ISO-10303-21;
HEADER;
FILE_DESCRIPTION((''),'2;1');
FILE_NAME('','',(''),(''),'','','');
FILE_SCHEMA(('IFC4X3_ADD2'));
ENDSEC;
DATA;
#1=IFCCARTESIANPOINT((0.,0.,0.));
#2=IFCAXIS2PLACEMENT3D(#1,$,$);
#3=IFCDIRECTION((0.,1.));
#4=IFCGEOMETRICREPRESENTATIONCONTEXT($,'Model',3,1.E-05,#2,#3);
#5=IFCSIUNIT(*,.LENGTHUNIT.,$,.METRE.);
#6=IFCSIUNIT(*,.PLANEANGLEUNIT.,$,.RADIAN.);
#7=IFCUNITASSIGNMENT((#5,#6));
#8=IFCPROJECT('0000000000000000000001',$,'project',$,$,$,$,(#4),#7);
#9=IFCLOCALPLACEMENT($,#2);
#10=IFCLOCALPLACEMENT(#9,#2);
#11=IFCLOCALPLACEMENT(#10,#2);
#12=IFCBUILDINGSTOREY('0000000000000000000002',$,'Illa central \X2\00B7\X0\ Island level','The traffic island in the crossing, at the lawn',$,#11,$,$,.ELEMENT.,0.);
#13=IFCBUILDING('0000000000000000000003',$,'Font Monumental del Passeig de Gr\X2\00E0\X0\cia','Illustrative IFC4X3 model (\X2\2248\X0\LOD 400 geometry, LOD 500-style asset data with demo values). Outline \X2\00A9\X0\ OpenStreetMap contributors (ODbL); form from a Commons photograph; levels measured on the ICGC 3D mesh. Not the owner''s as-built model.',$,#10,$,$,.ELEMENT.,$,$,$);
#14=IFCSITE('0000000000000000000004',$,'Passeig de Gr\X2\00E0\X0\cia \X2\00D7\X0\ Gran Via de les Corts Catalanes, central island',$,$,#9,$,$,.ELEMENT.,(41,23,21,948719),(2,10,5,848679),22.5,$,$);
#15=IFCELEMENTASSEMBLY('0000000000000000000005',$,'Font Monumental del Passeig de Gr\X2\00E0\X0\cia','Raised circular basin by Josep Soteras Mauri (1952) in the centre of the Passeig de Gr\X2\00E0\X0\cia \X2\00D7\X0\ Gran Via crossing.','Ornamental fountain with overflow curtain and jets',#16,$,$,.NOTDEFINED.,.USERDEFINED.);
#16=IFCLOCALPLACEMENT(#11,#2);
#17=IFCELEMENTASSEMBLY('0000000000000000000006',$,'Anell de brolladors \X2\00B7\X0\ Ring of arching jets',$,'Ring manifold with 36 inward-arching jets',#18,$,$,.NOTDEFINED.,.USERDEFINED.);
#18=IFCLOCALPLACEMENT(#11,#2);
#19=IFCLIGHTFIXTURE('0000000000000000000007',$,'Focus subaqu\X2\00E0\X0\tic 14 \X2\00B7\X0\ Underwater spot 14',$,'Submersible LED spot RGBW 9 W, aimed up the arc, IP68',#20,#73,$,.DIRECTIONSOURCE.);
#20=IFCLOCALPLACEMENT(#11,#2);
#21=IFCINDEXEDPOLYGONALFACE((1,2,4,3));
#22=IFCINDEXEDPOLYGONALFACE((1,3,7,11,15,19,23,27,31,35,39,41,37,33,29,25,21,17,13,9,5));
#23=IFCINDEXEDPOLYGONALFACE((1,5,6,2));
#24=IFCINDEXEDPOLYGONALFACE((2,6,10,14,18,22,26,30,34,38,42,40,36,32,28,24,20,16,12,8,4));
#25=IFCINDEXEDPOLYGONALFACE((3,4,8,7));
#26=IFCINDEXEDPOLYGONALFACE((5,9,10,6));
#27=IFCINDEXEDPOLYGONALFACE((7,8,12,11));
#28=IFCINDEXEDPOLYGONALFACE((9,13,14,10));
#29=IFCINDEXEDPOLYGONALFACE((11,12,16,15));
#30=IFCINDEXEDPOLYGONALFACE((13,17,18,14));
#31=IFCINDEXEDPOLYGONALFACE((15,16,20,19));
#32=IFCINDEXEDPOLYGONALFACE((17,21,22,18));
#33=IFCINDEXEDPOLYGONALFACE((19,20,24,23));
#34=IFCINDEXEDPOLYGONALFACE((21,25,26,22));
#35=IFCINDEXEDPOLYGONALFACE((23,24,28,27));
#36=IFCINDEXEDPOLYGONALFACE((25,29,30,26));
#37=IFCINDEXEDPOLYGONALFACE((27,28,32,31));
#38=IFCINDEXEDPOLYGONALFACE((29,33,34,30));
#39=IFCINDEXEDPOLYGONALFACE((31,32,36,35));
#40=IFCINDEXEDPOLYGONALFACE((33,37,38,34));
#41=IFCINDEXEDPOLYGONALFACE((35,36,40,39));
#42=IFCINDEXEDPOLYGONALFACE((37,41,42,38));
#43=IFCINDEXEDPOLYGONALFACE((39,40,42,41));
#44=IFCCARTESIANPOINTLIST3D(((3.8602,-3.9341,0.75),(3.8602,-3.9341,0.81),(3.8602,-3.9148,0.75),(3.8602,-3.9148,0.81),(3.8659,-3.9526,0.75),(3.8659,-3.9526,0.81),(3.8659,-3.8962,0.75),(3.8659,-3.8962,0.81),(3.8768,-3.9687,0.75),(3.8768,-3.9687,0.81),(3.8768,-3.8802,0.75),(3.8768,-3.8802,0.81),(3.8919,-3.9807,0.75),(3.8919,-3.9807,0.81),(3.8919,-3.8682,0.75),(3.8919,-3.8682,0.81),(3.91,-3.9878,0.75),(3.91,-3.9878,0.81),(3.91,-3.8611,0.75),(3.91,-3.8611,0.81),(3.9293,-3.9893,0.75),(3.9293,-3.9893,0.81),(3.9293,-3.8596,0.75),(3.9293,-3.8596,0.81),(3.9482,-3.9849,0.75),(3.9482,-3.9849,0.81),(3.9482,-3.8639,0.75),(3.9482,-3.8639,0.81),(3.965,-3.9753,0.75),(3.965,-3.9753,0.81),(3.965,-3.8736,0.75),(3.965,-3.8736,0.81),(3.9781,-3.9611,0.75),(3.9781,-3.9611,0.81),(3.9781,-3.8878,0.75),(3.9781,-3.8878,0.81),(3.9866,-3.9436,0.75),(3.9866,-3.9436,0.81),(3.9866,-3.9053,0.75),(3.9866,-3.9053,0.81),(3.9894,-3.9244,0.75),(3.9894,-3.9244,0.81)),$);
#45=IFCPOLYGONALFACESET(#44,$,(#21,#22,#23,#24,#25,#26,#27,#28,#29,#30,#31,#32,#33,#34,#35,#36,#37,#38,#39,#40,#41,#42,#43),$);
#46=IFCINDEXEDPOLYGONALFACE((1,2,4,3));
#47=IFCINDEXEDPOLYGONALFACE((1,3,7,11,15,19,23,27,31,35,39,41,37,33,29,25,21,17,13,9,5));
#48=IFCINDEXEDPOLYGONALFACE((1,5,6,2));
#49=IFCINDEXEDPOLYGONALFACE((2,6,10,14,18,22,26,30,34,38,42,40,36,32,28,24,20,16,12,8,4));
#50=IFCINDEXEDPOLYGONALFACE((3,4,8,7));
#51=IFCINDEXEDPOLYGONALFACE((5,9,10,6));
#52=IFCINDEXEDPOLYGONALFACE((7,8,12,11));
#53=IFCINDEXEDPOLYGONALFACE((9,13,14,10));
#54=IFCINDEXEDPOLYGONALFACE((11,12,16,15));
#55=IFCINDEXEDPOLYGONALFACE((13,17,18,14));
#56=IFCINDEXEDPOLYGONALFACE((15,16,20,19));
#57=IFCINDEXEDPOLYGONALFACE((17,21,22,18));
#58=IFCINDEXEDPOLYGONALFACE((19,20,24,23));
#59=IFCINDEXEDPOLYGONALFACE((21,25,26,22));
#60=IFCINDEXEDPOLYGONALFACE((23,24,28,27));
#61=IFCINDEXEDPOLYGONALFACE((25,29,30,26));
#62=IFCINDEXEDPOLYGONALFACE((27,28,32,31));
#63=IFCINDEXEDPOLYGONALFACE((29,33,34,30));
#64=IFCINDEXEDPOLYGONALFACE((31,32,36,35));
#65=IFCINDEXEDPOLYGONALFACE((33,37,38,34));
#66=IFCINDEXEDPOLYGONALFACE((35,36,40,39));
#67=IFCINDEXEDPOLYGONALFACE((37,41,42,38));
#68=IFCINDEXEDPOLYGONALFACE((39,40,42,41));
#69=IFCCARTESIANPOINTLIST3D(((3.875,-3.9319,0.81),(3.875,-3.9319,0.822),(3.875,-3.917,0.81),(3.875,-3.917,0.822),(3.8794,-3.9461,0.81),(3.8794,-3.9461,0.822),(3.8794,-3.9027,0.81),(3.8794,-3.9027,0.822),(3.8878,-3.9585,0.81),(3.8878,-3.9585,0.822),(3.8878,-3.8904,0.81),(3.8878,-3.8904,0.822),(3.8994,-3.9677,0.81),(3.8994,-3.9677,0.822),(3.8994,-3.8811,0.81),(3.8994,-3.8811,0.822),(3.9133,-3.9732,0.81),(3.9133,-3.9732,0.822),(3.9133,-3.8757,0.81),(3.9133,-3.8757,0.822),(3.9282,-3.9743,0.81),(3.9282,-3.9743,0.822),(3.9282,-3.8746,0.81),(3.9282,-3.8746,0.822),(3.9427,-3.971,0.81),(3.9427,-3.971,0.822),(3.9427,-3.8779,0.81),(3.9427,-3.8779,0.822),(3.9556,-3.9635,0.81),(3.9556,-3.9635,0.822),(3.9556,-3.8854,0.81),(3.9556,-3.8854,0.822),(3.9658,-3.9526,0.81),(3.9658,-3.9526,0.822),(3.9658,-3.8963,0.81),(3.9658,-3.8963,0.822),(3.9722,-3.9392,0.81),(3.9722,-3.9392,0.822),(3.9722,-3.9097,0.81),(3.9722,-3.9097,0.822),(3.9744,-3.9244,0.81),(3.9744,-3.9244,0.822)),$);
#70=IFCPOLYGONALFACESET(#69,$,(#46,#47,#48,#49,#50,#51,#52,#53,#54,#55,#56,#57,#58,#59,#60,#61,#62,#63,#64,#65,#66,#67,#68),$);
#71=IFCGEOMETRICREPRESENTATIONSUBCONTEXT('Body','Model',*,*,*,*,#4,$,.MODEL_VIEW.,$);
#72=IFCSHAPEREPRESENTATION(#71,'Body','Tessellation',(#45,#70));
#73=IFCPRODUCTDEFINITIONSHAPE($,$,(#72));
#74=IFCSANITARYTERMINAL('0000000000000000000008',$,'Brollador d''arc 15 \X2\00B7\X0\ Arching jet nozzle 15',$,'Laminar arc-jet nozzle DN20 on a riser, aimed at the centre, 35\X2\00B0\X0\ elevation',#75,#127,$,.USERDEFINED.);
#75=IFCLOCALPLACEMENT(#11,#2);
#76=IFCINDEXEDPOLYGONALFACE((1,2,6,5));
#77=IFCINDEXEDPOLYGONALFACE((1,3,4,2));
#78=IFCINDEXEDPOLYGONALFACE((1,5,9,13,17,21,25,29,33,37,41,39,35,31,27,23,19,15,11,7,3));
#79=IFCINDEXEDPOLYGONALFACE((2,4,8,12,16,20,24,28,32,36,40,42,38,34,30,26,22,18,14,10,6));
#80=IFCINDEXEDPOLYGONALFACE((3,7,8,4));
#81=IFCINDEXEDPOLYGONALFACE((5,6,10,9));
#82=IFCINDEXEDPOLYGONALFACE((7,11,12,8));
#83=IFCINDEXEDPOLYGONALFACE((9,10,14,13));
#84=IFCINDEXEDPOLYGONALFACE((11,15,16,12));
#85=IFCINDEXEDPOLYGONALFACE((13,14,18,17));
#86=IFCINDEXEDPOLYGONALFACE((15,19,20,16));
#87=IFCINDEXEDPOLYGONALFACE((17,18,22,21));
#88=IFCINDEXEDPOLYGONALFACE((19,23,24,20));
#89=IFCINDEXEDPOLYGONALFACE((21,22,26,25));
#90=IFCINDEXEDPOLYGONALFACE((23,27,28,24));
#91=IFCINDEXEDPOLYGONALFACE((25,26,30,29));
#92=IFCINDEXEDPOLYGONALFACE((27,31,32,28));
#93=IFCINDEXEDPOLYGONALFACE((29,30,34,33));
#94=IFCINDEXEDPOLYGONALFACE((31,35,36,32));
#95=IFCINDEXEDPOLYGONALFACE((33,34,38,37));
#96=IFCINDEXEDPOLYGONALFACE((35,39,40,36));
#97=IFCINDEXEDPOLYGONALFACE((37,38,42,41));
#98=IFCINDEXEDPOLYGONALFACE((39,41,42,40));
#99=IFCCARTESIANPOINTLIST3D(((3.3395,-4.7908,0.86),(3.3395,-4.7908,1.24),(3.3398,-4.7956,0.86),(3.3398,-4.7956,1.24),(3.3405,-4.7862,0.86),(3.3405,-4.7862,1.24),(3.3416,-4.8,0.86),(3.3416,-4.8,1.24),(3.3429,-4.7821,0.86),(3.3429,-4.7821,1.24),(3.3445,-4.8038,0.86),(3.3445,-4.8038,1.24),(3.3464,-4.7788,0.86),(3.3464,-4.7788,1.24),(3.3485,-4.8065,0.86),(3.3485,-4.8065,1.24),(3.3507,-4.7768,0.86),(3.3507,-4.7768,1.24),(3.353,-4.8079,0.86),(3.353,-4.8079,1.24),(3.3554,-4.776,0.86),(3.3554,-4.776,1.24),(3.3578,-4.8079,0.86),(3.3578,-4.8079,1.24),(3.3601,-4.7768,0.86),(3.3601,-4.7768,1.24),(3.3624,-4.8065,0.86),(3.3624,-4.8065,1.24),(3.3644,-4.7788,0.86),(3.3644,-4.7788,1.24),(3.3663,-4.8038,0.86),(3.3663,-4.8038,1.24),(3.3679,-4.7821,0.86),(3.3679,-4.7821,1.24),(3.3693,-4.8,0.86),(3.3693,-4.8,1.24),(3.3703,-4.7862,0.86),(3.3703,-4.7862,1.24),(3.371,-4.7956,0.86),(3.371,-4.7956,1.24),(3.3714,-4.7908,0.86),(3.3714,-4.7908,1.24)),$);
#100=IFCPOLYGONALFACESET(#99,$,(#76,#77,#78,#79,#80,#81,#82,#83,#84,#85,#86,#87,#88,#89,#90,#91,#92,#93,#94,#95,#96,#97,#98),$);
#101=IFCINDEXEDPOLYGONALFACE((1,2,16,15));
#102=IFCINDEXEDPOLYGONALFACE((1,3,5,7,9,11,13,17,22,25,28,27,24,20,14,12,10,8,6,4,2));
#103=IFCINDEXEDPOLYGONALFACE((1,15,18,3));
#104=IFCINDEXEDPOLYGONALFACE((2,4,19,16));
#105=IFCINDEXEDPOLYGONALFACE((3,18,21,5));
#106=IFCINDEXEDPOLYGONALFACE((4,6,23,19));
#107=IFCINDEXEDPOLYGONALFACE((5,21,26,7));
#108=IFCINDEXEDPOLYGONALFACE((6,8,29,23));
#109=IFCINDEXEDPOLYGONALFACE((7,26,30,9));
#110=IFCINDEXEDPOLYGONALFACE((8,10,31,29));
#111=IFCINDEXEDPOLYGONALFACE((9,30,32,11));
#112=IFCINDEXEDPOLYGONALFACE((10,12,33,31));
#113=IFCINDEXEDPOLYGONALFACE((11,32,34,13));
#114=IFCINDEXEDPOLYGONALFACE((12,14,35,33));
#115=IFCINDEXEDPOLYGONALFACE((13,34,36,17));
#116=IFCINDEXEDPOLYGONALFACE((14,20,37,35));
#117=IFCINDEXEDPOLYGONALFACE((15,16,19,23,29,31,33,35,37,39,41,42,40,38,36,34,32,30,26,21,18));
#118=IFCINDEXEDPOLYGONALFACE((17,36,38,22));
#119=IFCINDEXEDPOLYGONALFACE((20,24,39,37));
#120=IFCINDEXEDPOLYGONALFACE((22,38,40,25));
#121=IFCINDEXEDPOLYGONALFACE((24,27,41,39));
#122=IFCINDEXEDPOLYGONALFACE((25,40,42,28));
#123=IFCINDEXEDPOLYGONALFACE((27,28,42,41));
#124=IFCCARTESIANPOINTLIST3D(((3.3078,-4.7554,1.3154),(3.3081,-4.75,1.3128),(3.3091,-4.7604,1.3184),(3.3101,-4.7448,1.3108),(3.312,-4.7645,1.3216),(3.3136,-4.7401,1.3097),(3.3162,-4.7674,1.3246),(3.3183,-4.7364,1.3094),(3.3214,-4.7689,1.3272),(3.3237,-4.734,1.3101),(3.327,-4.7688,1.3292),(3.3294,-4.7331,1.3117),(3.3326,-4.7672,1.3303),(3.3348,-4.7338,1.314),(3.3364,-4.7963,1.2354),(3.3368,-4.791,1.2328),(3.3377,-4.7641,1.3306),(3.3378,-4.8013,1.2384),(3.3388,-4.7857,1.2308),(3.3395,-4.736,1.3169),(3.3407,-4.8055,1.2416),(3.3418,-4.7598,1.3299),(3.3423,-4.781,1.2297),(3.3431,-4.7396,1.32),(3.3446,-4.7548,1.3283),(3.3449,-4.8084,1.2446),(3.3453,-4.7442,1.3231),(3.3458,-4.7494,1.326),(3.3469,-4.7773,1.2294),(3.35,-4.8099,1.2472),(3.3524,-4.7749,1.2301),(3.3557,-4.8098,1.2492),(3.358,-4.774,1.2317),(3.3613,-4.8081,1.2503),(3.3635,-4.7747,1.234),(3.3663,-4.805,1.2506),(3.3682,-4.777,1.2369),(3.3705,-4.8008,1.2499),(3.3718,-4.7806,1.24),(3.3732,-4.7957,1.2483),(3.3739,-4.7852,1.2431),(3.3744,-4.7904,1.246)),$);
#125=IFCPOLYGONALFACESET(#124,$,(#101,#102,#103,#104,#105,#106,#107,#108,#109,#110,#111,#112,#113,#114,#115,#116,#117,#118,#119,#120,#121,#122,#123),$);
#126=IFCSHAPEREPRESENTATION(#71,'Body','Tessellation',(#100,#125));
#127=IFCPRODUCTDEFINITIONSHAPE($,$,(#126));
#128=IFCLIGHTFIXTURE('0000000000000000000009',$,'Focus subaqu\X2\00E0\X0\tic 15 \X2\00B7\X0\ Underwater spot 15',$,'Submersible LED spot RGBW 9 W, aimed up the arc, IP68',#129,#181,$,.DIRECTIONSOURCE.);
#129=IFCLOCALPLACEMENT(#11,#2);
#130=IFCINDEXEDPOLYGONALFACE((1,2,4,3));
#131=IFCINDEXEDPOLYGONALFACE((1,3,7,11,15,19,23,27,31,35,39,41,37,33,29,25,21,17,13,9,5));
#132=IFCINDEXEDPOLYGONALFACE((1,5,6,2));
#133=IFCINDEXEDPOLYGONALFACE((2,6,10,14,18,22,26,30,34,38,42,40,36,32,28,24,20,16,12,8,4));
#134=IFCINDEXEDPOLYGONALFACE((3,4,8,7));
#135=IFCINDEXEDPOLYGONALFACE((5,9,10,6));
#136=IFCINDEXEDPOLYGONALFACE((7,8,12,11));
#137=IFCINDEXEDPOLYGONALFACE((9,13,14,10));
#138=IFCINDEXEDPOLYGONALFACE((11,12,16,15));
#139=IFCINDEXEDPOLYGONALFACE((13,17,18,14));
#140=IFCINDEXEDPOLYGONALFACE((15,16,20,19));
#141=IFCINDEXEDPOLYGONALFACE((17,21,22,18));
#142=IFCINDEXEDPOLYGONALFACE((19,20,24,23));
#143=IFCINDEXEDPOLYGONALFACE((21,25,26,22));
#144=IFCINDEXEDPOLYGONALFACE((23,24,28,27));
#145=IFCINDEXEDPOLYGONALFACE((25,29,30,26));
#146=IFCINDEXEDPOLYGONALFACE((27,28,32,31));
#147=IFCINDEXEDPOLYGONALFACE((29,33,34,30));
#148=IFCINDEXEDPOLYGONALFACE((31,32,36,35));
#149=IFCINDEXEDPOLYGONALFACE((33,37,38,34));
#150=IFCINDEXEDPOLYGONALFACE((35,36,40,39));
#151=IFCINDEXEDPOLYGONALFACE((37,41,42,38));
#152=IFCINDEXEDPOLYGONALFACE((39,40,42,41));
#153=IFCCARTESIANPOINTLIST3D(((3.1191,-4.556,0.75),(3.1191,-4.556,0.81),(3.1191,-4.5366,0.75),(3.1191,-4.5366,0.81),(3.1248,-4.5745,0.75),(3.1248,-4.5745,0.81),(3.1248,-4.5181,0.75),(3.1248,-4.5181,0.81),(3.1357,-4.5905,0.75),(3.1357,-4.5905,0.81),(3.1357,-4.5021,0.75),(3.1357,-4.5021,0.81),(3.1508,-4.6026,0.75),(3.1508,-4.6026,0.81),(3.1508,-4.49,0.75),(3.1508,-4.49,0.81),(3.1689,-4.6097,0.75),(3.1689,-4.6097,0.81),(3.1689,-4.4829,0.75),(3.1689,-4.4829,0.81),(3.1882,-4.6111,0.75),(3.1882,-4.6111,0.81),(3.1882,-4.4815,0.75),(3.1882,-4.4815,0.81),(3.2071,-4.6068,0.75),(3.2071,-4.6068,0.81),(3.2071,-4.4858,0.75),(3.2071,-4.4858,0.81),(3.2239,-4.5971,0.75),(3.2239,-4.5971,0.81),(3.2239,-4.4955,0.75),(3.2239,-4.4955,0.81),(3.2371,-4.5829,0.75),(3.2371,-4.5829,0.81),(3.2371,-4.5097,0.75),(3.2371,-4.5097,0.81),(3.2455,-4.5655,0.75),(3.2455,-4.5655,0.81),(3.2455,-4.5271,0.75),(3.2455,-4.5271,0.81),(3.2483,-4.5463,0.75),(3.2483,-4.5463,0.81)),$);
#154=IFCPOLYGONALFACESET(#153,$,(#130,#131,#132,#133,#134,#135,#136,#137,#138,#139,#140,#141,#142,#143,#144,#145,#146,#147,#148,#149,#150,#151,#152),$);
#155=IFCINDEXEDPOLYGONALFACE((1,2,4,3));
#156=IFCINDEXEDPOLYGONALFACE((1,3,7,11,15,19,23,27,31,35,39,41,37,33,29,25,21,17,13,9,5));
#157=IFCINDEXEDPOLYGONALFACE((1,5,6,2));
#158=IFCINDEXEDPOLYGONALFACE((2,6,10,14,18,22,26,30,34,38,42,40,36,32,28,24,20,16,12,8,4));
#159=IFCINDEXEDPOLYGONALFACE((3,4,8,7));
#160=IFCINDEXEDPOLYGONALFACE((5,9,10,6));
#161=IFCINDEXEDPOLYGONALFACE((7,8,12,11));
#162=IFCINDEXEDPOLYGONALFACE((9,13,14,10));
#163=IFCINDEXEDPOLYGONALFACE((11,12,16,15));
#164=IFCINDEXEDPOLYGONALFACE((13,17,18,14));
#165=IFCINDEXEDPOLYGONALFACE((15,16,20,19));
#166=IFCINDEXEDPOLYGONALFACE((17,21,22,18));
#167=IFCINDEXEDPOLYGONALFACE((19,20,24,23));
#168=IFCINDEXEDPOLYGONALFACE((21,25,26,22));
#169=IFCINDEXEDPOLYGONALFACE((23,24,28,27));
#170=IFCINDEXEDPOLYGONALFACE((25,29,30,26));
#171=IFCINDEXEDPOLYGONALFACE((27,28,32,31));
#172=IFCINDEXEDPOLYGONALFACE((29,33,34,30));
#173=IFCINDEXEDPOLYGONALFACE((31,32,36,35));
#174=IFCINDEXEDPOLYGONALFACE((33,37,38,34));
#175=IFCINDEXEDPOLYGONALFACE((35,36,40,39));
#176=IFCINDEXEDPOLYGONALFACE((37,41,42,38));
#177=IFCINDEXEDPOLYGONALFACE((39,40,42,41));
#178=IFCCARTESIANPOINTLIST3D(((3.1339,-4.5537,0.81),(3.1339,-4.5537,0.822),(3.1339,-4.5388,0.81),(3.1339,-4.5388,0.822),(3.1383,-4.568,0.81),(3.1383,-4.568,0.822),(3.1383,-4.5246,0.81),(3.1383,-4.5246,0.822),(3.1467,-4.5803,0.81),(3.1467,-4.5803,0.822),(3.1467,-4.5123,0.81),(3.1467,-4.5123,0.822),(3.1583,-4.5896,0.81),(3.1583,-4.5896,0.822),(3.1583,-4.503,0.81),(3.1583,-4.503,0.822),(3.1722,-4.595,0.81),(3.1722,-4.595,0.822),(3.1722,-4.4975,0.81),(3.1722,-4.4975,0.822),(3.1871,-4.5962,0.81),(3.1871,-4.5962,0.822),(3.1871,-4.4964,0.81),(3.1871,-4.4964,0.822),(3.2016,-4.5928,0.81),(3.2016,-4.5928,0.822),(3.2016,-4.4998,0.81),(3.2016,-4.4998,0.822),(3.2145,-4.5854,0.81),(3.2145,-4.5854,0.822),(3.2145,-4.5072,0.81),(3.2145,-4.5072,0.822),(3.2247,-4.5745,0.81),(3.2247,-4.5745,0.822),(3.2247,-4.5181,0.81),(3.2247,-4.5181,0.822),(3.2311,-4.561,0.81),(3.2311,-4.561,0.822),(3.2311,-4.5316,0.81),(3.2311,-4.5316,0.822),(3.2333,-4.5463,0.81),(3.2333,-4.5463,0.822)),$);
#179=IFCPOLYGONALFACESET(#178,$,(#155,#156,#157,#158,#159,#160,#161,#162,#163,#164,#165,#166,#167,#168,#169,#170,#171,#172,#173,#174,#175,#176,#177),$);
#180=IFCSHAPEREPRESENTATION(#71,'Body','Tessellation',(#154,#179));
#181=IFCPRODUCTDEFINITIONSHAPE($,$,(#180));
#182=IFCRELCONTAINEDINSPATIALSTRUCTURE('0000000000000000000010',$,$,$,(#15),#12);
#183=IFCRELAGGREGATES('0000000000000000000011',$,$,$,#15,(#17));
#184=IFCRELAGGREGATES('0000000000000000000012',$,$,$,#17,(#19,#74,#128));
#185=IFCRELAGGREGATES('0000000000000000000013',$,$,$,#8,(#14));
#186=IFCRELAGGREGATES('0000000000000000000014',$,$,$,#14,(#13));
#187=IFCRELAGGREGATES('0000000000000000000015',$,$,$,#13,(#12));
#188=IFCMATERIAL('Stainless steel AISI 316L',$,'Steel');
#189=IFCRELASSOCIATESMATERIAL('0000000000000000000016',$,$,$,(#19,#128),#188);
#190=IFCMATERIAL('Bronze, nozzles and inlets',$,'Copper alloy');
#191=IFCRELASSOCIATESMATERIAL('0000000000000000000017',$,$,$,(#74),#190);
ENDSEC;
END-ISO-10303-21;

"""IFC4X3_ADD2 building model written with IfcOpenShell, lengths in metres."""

from ifc_helpers import new_model, si_unit, direction, frame, origin, origin_2d_with_axis, place, context, subcontext, project, spatial, circle, extrude, material, element, aggregate, save


model = new_model("IFC4X3_ADD2")

# Units and contexts
model_context = context("Model", 3, precision=1e-05, world=origin(), true_north=direction((0.0, 1.0)))
body_context = subcontext(model_context, "Body", "Model", "MODEL_VIEW")
ifc_project = project(units=[si_unit("LENGTHUNIT", "METRE"), si_unit("PLANEANGLEUNIT", "RADIAN")], contexts=[model_context])

# Site, building, storey
site_placement = place(None, origin())
site = spatial("IfcSite", under=ifc_project, at=site_placement, Name="Passeig de Gràcia × Gran Via de les Corts Catalanes, central island", CompositionType="ELEMENT", RefLatitude=(41, 23, 21, 948719), RefLongitude=(2, 10, 5, 848679), RefElevation=22.5)
building_placement = place(site_placement, origin())
building = spatial("IfcBuilding", under=site, at=building_placement, Name="Font Monumental del Passeig de Gràcia", Description="Illustrative IFC4X3 model (≈LOD 400 geometry, LOD 500-style asset data with demo values). Outline © OpenStreetMap contributors (ODbL); form from a Commons photograph; levels measured on the ICGC 3D mesh. Not the owner's as-built model.", CompositionType="ELEMENT")
storey_placement = place(building_placement, origin())
storey = spatial("IfcBuildingStorey", under=building, at=storey_placement, Name="Illa central · Island level", Description="The traffic island in the crossing, at the lawn", CompositionType="ELEMENT", Elevation=0.0)

# Element assemblies, light fixtures, sanitary terminal
assembly_1_placement = place(building_placement, origin())
assembly_1 = element("IfcElementAssembly", 1, at=assembly_1_placement, inside=storey, Name="Font Monumental del Passeig de Gràcia", Description="Raised circular basin by Josep Soteras Mauri (1952) in the centre of the Passeig de Gràcia × Gran Via crossing.", ObjectType="Ornamental fountain with overflow curtain and jets", AssemblyPlace="NOTDEFINED", PredefinedType="USERDEFINED")
assembly_2_placement = place(building_placement, origin())
assembly_2 = element("IfcElementAssembly", 2, at=assembly_2_placement, Name="Anell de brolladors · Ring of arching jets", ObjectType="Ring manifold with 36 inward-arching jets", AssemblyPlace="NOTDEFINED", PredefinedType="USERDEFINED")
aggregate(assembly_1, [assembly_2])
ifc_material_1 = material(Name="Bronze, nozzles and inlets", Category="Copper alloy")
ifc_material_2 = material(Name="Stainless steel AISI 316L", Category="Steel")
light_fixture_1_placement = place(building_placement, origin())
light_fixture_1 = element("IfcLightFixture", 3, at=light_fixture_1_placement, material=ifc_material_2, Name="Focus subaquàtic 14 · Underwater spot 14", ObjectType="Submersible LED spot RGBW 9 W, aimed up the arc, IP68", PredefinedType="DIRECTIONSOURCE", context=body_context, shape_type="SweptSolid", body=[
    extrude(circle(Radius=0.065, at=origin_2d_with_axis()), frame((3.9244, -3.9244, 0.75)), (0.0, 0.0, 1.0), 0.06),
    extrude(circle(Radius=0.05, at=origin_2d_with_axis()), frame((3.9244, -3.9244, 0.81)), (0.0, 0.0, 1.0), 0.012),
])
sanitary_terminal_1_placement = place(building_placement, origin())
sanitary_terminal_1 = element("IfcSanitaryTerminal", 4, at=sanitary_terminal_1_placement, material=ifc_material_1, Name="Brollador d'arc 15 · Arching jet nozzle 15", ObjectType="Laminar arc-jet nozzle DN20 on a riser, aimed at the centre, 35° elevation", PredefinedType="USERDEFINED", context=body_context, shape_type="SweptSolid", body=[
    extrude(circle(Radius=0.016, at=origin_2d_with_axis()), frame((3.3554, -4.792, 0.86), z_axis=(0.0, 0.0, 1.0), x_axis=(0.0, 1.0, 0.0)), (0.0, 0.0, 1.0), 0.38),
    extrude(circle(Radius=0.02, at=origin_2d_with_axis()), frame((3.3554, -4.792, 1.24), z_axis=(-0.303995, 0.43415, 0.847998), x_axis=(0.819152, 0.573576, 0.0)), (0.0, 0.0, 1.0), 0.0943),
])
light_fixture_2_placement = place(building_placement, origin())
light_fixture_2 = element("IfcLightFixture", 5, at=light_fixture_2_placement, material=ifc_material_2, Name="Focus subaquàtic 15 · Underwater spot 15", ObjectType="Submersible LED spot RGBW 9 W, aimed up the arc, IP68", PredefinedType="DIRECTIONSOURCE", context=body_context, shape_type="SweptSolid", body=[
    extrude(circle(Radius=0.065, at=origin_2d_with_axis()), frame((3.1833, -4.5463, 0.75)), (0.0, 0.0, 1.0), 0.06),
    extrude(circle(Radius=0.05, at=origin_2d_with_axis()), frame((3.1833, -4.5463, 0.81)), (0.0, 0.0, 1.0), 0.012),
])
aggregate(assembly_2, [light_fixture_1, sanitary_terminal_1, light_fixture_2])

save(model, "model.ifc")
